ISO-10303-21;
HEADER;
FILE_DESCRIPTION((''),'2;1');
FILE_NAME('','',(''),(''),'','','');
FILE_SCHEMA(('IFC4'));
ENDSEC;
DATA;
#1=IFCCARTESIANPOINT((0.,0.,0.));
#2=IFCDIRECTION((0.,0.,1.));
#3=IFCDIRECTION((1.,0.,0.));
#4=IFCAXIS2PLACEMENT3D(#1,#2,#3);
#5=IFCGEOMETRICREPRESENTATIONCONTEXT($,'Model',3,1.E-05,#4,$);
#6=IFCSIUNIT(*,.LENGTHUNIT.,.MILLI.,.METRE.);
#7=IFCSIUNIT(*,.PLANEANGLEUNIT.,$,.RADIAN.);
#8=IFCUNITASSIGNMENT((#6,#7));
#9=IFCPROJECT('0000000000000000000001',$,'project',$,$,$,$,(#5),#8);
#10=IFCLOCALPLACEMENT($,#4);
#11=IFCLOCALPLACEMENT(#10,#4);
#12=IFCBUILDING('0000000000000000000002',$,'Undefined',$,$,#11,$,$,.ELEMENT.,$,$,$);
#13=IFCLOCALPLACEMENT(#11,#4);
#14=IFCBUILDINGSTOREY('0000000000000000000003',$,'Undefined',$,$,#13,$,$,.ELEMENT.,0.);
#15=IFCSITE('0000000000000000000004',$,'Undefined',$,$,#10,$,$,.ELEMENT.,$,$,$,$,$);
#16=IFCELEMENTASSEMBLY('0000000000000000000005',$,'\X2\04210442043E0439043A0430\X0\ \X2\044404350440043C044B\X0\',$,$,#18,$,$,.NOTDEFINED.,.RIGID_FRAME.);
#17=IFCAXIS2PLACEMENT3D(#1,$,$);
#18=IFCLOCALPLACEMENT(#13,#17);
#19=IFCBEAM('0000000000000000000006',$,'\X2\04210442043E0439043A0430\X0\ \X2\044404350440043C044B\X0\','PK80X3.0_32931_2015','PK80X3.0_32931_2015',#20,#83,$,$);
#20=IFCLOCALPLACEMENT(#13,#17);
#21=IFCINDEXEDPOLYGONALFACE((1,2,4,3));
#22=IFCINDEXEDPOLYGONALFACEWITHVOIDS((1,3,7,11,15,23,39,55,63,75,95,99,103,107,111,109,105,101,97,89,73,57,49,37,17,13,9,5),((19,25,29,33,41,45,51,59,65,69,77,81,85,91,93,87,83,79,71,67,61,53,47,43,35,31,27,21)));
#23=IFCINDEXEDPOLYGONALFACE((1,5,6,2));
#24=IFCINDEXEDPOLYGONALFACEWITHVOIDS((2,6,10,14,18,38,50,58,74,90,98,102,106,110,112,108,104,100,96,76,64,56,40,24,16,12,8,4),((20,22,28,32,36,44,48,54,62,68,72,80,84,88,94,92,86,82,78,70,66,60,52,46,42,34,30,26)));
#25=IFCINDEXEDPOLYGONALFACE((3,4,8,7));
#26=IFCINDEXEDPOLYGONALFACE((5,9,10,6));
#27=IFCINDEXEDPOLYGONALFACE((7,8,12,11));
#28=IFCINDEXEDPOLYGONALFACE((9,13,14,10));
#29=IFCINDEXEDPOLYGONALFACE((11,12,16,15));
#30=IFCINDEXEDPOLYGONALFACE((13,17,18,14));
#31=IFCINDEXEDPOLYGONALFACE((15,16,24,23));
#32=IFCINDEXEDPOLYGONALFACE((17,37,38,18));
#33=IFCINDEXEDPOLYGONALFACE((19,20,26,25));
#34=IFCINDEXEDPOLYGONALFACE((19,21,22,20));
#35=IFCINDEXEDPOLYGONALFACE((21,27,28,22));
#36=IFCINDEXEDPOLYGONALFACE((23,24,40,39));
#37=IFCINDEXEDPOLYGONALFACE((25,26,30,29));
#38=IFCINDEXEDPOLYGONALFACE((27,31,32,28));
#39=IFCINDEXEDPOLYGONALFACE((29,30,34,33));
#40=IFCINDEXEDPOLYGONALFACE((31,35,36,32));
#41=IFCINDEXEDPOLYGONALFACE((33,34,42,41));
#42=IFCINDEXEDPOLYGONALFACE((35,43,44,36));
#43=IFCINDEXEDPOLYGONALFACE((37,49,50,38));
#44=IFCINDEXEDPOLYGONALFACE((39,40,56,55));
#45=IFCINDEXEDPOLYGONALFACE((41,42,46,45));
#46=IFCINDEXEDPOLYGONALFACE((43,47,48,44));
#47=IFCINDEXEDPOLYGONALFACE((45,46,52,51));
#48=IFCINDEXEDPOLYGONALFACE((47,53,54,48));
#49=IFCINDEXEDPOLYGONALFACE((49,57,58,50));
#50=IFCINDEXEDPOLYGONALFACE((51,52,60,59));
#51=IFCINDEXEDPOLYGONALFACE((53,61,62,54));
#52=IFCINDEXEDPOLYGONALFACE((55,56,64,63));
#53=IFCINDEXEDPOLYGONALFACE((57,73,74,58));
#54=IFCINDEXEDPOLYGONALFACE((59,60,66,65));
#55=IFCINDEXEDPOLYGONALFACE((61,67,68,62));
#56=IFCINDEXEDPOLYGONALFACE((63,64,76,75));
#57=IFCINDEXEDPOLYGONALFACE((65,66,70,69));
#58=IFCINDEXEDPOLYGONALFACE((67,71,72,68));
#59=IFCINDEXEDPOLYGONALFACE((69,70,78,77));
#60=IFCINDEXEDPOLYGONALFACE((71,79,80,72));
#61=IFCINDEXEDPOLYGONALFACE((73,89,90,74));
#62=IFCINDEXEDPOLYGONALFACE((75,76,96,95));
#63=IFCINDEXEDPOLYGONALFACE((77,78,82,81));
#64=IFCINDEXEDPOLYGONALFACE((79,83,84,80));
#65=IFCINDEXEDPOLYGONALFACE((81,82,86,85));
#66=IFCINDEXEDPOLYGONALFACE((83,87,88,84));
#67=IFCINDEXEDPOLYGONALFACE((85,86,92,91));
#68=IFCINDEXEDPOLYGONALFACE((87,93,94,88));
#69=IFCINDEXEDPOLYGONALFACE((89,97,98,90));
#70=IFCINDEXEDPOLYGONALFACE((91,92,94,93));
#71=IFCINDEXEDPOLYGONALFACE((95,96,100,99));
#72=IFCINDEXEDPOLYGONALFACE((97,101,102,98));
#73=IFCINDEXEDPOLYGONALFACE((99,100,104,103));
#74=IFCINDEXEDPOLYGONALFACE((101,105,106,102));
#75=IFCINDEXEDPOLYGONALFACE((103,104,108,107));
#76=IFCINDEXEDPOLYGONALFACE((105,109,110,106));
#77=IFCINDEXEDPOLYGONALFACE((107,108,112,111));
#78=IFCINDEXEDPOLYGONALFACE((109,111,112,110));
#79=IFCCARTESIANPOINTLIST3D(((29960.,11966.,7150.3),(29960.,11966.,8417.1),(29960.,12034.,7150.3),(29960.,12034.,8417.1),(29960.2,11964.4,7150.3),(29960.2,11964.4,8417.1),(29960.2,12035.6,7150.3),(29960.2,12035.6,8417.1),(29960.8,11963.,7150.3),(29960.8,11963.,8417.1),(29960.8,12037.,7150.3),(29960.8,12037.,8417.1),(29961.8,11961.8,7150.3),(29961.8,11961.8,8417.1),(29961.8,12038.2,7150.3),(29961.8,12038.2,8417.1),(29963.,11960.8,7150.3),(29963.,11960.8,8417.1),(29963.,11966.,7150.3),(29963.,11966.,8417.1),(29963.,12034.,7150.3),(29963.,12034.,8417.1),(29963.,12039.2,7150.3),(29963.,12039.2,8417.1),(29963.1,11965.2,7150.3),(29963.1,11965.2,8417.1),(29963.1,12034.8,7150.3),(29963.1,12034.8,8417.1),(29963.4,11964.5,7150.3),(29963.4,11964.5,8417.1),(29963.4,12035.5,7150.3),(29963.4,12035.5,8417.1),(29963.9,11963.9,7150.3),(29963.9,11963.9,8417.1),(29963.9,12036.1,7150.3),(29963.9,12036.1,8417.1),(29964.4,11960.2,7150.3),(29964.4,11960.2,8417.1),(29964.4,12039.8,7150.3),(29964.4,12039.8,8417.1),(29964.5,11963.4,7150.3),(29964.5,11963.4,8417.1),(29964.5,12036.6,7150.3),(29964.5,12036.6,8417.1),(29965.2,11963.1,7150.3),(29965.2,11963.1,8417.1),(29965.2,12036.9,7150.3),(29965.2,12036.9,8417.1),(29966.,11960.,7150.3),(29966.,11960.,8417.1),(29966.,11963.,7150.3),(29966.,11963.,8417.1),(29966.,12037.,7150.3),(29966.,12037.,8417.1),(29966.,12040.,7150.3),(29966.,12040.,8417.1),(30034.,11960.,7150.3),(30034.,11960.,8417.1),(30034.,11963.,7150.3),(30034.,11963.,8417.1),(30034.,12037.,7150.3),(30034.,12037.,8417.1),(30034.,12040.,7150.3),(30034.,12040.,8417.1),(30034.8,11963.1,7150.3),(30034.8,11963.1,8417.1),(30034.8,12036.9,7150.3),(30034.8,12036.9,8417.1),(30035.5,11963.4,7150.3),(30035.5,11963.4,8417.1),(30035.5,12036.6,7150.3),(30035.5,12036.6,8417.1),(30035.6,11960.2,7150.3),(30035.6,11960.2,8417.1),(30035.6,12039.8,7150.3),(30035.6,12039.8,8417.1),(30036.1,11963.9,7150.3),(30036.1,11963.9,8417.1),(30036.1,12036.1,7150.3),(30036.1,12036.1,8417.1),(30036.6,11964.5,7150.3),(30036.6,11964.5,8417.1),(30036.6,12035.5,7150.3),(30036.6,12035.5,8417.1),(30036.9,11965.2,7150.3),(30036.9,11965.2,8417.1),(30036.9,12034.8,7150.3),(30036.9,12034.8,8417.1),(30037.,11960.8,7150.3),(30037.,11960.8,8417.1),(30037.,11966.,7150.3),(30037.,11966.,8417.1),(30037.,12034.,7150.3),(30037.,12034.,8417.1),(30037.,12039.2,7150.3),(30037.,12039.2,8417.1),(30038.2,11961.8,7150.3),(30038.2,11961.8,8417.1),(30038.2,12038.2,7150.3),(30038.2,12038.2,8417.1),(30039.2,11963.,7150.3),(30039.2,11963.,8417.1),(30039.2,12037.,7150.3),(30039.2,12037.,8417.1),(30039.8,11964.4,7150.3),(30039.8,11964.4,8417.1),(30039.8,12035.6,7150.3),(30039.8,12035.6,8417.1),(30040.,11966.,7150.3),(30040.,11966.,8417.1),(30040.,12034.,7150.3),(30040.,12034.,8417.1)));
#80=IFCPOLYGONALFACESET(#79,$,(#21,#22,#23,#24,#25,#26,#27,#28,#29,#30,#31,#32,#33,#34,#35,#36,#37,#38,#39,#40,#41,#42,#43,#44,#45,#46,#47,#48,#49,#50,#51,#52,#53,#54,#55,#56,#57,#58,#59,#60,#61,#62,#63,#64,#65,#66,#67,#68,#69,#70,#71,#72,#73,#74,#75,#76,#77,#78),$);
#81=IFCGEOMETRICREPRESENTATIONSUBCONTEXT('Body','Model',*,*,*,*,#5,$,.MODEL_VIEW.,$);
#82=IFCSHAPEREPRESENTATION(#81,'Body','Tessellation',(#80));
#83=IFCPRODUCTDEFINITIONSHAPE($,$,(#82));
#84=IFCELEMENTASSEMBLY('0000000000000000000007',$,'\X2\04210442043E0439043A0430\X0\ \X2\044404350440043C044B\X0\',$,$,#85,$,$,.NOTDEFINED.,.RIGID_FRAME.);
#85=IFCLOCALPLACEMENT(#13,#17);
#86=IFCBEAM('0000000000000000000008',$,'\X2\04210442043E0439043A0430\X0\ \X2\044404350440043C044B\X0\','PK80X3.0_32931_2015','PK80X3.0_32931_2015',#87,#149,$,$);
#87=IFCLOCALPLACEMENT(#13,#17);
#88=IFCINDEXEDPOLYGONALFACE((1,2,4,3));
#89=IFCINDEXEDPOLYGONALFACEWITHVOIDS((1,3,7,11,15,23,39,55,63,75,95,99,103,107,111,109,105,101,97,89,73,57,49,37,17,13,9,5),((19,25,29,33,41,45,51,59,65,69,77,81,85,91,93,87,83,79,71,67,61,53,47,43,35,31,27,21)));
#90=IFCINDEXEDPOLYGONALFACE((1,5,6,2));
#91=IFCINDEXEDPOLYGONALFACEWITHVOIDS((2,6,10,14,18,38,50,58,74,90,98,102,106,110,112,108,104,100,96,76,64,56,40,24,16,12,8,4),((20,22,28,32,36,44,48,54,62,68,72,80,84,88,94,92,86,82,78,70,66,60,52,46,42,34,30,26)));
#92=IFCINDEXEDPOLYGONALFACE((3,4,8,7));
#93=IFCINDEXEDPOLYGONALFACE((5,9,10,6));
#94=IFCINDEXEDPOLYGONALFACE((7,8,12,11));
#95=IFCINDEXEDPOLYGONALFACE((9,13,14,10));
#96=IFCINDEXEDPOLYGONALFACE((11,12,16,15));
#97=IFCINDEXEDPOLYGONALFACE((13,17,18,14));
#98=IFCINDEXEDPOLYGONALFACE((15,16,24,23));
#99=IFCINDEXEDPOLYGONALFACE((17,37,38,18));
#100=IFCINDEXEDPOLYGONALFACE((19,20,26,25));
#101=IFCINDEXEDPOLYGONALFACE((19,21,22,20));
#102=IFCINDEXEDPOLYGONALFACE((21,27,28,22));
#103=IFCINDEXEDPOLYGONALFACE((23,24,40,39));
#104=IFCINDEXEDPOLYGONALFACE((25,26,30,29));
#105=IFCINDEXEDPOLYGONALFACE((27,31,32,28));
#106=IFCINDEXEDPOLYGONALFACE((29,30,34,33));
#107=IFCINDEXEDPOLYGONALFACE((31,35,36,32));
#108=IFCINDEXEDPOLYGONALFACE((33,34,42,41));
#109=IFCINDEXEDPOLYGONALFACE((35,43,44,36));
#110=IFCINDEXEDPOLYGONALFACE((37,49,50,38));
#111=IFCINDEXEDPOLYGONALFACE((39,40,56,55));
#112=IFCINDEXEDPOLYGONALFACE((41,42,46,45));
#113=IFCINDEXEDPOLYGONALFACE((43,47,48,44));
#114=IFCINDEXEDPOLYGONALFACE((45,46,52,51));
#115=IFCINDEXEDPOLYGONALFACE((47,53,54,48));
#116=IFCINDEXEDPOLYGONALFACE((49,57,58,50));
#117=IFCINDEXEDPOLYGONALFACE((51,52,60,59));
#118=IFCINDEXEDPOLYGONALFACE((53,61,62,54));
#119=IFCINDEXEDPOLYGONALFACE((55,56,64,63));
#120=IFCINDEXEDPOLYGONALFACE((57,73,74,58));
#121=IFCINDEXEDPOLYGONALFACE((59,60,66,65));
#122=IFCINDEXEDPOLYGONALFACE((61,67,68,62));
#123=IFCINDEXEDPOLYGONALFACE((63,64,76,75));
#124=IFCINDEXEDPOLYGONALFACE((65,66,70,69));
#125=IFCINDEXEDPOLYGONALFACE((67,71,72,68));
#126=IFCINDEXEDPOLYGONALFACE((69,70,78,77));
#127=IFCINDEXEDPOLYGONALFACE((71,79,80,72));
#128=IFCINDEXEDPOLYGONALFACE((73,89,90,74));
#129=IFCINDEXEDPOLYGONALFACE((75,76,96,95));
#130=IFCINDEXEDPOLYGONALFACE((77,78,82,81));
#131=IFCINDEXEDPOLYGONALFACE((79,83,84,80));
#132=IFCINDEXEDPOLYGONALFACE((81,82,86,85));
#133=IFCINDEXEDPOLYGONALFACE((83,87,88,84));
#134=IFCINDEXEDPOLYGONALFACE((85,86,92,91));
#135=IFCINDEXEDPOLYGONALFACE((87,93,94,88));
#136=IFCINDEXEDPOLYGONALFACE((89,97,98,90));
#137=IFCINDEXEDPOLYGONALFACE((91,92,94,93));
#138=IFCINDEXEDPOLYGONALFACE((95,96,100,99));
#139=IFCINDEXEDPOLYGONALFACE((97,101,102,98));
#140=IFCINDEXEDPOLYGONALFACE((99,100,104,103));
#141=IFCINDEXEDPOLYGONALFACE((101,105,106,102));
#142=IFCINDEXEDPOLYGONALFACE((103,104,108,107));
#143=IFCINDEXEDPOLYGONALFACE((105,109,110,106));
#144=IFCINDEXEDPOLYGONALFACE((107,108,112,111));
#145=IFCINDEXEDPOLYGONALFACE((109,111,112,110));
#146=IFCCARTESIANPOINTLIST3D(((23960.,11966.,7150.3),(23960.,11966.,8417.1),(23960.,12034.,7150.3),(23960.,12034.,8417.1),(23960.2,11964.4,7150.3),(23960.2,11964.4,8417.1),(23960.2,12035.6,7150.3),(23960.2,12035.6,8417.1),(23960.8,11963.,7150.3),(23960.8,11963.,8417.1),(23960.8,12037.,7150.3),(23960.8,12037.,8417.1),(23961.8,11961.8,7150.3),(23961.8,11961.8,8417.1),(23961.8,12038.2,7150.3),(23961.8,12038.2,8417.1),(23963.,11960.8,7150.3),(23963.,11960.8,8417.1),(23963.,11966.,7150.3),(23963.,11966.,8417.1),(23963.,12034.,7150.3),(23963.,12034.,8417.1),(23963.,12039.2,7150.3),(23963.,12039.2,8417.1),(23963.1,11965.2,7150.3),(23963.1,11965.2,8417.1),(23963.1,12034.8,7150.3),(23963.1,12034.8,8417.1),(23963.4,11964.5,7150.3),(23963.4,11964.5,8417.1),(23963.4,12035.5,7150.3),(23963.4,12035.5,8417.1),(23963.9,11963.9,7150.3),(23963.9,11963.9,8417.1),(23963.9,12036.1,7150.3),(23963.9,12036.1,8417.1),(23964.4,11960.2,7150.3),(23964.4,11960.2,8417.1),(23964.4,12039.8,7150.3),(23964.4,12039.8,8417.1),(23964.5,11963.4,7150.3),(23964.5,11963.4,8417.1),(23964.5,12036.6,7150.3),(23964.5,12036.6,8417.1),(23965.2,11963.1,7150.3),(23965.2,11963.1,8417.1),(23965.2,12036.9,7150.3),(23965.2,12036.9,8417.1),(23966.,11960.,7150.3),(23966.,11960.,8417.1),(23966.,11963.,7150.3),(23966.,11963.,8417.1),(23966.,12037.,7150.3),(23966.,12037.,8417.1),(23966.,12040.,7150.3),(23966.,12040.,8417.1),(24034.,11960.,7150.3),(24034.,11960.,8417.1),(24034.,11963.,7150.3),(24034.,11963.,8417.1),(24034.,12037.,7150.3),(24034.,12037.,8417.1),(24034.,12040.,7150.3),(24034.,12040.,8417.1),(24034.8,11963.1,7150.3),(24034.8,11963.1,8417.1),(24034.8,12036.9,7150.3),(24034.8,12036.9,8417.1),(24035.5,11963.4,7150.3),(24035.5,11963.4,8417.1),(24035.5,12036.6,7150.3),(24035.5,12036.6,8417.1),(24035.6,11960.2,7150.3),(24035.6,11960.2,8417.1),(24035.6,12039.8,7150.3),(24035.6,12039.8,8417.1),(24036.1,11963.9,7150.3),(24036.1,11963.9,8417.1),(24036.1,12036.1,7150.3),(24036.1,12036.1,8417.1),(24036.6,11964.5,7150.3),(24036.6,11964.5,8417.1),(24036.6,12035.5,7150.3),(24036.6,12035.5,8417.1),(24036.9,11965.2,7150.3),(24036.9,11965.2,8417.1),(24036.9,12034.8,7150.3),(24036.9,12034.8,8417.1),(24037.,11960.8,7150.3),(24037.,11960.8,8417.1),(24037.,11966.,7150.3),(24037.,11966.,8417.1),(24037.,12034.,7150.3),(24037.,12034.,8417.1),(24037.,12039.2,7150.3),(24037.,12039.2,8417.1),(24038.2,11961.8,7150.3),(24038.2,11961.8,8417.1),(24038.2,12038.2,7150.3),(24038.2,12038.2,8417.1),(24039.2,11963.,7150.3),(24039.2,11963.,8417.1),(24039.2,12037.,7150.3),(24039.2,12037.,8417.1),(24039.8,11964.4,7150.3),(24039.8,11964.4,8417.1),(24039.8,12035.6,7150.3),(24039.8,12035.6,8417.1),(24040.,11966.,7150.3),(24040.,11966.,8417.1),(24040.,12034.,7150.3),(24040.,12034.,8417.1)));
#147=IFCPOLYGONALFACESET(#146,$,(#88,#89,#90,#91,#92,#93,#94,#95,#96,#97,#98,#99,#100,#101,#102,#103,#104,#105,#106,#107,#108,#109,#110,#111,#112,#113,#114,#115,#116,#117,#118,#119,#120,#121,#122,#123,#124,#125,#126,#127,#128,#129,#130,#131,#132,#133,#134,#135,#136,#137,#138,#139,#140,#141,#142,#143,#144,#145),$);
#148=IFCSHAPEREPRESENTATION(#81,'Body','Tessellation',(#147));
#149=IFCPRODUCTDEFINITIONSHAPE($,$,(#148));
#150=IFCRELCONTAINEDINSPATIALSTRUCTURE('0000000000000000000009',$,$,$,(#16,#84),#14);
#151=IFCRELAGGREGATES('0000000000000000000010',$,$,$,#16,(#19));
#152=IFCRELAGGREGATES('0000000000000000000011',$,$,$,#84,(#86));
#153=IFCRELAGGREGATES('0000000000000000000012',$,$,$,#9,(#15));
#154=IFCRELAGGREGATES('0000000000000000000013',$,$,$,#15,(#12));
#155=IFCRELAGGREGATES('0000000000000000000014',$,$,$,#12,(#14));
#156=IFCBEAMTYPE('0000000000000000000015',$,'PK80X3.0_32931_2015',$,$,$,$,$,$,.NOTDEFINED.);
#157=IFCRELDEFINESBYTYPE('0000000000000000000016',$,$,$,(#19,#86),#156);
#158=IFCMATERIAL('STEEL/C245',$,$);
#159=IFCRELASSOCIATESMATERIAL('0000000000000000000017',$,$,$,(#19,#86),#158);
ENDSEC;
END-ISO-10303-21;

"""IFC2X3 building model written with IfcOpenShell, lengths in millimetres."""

from ifc_helpers import new_model, si_unit, frame, origin_with_axes, origin_2d_with_axis, place, context, subcontext, project, spatial, hollow_rectangle, extrude, material, type_object, element, aggregate, save


model = new_model("IFC2X3")

# Units and contexts
model_context = context("Model", 3, precision=1e-05, world=origin_with_axes())
body_context = subcontext(model_context, "Body", "Model", "MODEL_VIEW")
ifc_project = project(units=[si_unit("LENGTHUNIT", "METRE", prefix="MILLI"), si_unit("PLANEANGLEUNIT", "RADIAN")], contexts=[model_context])

# Site, building, storey
site_placement = place(None, origin_with_axes())
site = spatial("IfcSite", under=ifc_project, at=site_placement, Name="Undefined", CompositionType="ELEMENT")
building_placement = place(site_placement, origin_with_axes())
building = spatial("IfcBuilding", under=site, at=building_placement, Name="Undefined", CompositionType="ELEMENT")
storey_placement = place(building_placement, origin_with_axes())
storey = spatial("IfcBuildingStorey", under=building, at=storey_placement, Name="Undefined", CompositionType="ELEMENT", Elevation=0.0)

# Element assemblies, beams
ifc_material_1 = material(Name="STEEL/C245")
assembly_1_placement = place(storey_placement, origin_with_axes())
assembly_1 = element("IfcElementAssembly", 1, at=assembly_1_placement, inside=storey, Name="Стойка фермы", AssemblyPlace="NOTDEFINED", PredefinedType="RIGID_FRAME")
beam_type_1 = type_object("IfcBeamType", Name="PK80X3.0_32931_2015", PredefinedType="NOTDEFINED")
beam_1_placement = place(assembly_1_placement, frame((30000.0, 12000.0, 8417.1), z_axis=(1.0, 0.0, 0.0), x_axis=(0.0, 0.0, -1.0)))
beam_1 = element("IfcBeam", 2, at=beam_1_placement, type_object=beam_type_1, material=ifc_material_1, Name="Стойка фермы", Description="PK80X3.0_32931_2015", ObjectType="PK80X3.0_32931_2015", context=body_context, shape_type="SweptSolid", body=[
    extrude(hollow_rectangle(XDim=80.0, YDim=80.0, WallThickness=3.0, InnerFilletRadius=3.0, OuterFilletRadius=6.0, at=origin_2d_with_axis()), frame((1266.8, 0.0, 0.0), z_axis=(-1.0, 0.0, 0.0), x_axis=(0.0, -1.0, 0.0)), (0.0, 0.0, 1.0), 1266.8),
])
aggregate(assembly_1, [beam_1])
assembly_2_placement = place(storey_placement, origin_with_axes())
assembly_2 = element("IfcElementAssembly", 3, at=assembly_2_placement, inside=storey, Name="Стойка фермы", AssemblyPlace="NOTDEFINED", PredefinedType="RIGID_FRAME")
beam_2_placement = place(assembly_2_placement, frame((24000.0, 12000.0, 8417.1), z_axis=(1.0, 0.0, 0.0), x_axis=(0.0, 0.0, -1.0)))
beam_2 = element("IfcBeam", 4, at=beam_2_placement, type_object=beam_type_1, material=ifc_material_1, Name="Стойка фермы", Description="PK80X3.0_32931_2015", ObjectType="PK80X3.0_32931_2015", context=body_context, shape_type="SweptSolid", body=[
    extrude(hollow_rectangle(XDim=80.0, YDim=80.0, WallThickness=3.0, InnerFilletRadius=3.0, OuterFilletRadius=6.0, at=origin_2d_with_axis()), frame((1266.8, 0.0, 0.0), z_axis=(-1.0, 0.0, 0.0), x_axis=(0.0, -1.0, 0.0)), (0.0, 0.0, 1.0), 1266.8),
])
aggregate(assembly_2, [beam_2])

save(model, "model.ifc")
